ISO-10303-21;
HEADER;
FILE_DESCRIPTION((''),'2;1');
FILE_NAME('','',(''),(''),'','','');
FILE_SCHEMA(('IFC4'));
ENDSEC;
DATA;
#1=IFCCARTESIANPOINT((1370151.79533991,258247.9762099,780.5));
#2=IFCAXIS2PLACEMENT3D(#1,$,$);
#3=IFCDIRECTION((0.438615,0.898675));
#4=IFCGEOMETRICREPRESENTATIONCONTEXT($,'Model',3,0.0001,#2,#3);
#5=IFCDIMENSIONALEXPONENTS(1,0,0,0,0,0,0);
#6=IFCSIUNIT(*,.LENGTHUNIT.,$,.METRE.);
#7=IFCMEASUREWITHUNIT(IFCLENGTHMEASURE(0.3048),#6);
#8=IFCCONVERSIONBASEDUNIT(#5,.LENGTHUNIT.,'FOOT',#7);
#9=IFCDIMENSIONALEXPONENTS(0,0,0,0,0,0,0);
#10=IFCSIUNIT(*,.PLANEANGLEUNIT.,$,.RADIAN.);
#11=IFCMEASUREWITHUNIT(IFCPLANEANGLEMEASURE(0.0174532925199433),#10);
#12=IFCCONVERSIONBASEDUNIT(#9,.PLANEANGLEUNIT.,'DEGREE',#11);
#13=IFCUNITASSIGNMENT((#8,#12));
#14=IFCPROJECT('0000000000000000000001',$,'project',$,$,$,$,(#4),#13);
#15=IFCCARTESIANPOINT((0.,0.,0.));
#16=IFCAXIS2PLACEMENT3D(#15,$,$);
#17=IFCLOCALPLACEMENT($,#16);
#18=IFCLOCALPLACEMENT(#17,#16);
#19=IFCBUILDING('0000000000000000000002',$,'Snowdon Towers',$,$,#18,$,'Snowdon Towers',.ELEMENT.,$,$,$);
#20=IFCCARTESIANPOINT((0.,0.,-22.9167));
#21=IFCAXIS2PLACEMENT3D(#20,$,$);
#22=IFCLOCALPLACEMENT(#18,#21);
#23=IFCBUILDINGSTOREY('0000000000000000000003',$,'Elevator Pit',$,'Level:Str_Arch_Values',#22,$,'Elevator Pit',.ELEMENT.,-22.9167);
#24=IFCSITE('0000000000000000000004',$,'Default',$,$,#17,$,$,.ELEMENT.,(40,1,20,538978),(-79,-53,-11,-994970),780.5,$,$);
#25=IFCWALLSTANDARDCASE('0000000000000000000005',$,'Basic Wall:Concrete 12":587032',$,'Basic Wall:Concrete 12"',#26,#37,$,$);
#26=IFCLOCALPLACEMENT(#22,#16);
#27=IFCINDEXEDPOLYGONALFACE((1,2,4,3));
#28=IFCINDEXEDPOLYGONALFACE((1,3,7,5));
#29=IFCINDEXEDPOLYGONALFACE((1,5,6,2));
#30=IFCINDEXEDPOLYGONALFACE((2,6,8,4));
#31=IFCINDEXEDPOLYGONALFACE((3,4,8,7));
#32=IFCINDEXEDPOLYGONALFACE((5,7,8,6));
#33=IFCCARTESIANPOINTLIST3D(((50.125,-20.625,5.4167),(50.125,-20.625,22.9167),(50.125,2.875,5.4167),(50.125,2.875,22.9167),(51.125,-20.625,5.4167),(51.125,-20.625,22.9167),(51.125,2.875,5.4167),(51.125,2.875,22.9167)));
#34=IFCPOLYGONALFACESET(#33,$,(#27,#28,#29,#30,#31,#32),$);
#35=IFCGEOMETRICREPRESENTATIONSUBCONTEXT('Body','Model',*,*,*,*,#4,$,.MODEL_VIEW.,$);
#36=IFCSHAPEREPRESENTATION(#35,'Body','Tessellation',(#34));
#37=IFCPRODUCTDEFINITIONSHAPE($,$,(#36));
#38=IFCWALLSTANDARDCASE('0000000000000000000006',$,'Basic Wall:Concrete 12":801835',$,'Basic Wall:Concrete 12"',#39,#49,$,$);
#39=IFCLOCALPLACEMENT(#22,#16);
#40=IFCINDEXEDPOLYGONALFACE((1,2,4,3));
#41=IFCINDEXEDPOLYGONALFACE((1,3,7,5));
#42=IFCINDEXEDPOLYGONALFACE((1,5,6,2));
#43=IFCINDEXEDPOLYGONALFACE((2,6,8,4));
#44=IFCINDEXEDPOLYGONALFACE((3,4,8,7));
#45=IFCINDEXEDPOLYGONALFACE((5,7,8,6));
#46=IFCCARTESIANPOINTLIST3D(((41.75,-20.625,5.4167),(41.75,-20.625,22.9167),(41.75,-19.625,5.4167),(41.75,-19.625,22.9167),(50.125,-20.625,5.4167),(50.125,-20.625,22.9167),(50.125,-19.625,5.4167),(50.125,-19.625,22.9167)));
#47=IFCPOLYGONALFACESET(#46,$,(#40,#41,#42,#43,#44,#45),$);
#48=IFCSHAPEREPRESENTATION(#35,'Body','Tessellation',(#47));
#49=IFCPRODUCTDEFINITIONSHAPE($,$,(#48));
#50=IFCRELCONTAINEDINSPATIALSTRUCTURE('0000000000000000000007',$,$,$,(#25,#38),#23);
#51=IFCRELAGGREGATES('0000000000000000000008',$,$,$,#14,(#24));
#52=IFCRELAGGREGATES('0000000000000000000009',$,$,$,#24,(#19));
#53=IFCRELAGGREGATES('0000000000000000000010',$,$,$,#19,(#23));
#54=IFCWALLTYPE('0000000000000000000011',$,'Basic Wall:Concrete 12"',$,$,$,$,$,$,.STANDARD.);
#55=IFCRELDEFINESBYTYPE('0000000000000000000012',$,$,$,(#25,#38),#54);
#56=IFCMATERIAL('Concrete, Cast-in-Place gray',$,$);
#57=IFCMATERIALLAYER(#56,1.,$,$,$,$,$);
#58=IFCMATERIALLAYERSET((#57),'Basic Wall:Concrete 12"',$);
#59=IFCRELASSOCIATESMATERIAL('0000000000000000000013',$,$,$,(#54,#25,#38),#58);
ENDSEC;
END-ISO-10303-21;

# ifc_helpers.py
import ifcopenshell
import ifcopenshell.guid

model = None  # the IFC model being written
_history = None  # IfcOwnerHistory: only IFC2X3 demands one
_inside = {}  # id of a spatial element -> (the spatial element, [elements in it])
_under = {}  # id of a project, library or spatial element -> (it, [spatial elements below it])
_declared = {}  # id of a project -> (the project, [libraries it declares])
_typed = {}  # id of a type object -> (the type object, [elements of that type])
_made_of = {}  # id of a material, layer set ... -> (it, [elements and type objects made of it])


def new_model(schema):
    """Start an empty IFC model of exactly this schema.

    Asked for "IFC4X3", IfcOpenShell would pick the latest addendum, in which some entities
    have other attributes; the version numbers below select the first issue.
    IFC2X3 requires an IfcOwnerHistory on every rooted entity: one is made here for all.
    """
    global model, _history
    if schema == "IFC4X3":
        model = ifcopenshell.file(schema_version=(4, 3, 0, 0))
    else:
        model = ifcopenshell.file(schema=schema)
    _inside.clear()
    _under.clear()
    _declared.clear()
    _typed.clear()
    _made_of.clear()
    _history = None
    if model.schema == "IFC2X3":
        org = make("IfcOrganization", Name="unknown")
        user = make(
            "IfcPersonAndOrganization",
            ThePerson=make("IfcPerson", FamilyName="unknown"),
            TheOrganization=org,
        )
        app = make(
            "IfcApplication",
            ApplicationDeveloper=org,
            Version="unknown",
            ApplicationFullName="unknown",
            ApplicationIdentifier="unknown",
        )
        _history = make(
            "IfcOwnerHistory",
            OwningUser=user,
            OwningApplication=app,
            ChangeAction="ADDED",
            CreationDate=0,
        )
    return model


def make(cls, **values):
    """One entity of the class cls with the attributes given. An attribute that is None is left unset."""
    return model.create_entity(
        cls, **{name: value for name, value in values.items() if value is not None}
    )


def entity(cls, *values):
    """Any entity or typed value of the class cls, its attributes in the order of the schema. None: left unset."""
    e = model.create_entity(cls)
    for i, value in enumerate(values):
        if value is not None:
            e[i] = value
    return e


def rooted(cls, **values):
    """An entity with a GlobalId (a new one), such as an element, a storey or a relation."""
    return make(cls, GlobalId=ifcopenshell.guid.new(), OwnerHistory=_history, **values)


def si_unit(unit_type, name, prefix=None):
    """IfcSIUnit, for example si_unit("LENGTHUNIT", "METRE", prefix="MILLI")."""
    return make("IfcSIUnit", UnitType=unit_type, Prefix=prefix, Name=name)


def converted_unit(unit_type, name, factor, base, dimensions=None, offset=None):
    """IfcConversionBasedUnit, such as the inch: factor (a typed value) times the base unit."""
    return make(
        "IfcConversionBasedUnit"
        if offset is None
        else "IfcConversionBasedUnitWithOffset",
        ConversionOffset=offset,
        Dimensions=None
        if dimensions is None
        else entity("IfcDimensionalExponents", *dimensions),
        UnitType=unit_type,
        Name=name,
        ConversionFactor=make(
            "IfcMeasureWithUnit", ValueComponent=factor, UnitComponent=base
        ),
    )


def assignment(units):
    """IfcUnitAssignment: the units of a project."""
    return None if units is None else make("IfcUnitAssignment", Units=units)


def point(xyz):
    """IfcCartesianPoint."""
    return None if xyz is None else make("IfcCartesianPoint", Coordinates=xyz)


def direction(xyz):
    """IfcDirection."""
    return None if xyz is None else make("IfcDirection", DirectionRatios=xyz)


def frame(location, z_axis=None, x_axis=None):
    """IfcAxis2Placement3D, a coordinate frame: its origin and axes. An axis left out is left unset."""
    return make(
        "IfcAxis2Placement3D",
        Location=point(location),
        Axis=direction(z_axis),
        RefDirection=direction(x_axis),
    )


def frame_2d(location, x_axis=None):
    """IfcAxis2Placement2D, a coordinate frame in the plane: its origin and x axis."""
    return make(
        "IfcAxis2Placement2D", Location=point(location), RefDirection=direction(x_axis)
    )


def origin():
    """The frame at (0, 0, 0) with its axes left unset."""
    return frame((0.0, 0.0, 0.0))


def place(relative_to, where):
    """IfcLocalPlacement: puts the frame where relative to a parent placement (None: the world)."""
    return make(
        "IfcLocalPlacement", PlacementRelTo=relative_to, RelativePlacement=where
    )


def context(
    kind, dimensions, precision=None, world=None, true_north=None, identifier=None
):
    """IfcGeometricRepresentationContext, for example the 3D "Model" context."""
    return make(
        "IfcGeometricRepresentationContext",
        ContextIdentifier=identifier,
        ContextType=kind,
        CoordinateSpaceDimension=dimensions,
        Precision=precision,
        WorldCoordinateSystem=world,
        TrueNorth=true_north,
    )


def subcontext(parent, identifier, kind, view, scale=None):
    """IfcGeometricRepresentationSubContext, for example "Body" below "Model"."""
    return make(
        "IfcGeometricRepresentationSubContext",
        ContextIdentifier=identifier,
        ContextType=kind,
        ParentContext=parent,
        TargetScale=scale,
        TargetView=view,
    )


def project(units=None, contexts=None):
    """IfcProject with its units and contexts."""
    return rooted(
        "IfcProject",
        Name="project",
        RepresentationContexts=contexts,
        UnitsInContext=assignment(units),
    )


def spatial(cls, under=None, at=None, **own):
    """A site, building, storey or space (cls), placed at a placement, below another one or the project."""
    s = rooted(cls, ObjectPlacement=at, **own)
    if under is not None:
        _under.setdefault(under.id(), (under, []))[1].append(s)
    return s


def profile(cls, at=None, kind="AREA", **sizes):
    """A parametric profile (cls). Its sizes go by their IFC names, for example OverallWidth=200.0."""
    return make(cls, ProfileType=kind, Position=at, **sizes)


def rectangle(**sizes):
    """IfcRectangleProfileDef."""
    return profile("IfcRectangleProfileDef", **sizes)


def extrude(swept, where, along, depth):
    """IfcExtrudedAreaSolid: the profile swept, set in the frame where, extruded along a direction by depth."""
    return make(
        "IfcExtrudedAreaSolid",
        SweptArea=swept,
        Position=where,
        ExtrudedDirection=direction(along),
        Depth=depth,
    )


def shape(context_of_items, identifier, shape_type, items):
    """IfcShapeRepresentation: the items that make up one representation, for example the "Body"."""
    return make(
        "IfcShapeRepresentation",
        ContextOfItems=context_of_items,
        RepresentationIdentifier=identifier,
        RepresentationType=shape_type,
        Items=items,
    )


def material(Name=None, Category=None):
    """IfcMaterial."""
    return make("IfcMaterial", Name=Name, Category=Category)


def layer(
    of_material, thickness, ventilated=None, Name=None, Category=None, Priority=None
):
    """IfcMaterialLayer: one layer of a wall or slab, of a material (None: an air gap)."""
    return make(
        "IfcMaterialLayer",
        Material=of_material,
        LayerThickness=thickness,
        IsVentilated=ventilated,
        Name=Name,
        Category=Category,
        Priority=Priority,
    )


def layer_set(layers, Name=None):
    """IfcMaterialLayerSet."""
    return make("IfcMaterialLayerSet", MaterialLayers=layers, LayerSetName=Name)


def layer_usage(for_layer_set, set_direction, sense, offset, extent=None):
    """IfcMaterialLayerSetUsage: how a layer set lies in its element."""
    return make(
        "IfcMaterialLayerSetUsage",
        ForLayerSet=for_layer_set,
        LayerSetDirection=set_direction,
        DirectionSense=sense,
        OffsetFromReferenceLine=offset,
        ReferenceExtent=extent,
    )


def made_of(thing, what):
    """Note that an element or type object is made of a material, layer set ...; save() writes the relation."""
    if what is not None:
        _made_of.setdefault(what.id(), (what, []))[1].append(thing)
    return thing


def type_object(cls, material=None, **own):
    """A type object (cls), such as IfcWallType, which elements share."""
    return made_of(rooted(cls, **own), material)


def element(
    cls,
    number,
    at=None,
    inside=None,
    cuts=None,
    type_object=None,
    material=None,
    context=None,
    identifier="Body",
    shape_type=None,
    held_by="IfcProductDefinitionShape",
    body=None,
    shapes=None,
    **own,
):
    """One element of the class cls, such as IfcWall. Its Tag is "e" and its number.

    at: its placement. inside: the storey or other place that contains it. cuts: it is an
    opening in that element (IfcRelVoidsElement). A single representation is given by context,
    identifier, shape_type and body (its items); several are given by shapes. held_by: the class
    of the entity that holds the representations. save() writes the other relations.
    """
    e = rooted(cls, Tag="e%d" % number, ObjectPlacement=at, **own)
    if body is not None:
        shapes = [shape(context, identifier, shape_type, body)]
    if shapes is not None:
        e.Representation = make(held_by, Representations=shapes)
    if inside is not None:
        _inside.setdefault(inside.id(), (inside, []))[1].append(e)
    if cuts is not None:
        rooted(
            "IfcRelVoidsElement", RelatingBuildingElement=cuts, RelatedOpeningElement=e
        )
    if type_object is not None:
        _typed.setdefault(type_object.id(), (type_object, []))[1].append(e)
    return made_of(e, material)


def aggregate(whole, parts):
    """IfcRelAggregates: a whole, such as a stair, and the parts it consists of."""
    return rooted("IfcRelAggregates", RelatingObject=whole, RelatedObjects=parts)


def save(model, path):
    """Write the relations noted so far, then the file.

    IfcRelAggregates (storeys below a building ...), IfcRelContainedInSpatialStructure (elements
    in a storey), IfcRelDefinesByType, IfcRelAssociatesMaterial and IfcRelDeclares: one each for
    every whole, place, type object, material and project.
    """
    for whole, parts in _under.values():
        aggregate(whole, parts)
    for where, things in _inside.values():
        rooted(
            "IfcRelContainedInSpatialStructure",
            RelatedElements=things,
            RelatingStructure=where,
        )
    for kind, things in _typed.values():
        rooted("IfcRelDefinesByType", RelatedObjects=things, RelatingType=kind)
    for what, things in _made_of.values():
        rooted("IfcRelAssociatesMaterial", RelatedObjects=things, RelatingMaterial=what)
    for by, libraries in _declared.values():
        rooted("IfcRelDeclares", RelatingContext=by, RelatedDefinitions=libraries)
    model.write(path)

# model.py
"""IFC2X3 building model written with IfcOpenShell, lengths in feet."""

from ifc_helpers import new_model, entity, si_unit, converted_unit, direction, frame, frame_2d, origin, place, context, subcontext, project, spatial, rectangle, extrude, material, layer, layer_set, layer_usage, type_object, element, save


model = new_model("IFC2X3")

# Units and contexts
model_context = context("Model", 3, precision=0.0001, world=frame((1370151.79533991, 258247.9762099, 780.5)), true_north=direction((0.438615, 0.898675)))
body_context = subcontext(model_context, "Body", "Model", "MODEL_VIEW")
ifc_project = project(units=[converted_unit("LENGTHUNIT", "FOOT", entity("IfcLengthMeasure", 0.3048), si_unit("LENGTHUNIT", "METRE"), dimensions=[1, 0, 0, 0, 0, 0, 0]), converted_unit("PLANEANGLEUNIT", "DEGREE", entity("IfcPlaneAngleMeasure", 0.0174532925199433), si_unit("PLANEANGLEUNIT", "RADIAN"), dimensions=[0, 0, 0, 0, 0, 0, 0])], contexts=[model_context])

# Site, building, storey
site_placement = place(None, origin())
site = spatial("IfcSite", under=ifc_project, at=site_placement, Name="Default", CompositionType="ELEMENT", RefLatitude=(40, 1, 20, 538978), RefLongitude=(-79, -53, -11, -994970), RefElevation=780.5)
building_placement = place(site_placement, origin())
building = spatial("IfcBuilding", under=site, at=building_placement, Name="Snowdon Towers", LongName="Snowdon Towers", CompositionType="ELEMENT")
storey_placement = place(building_placement, frame((0.0, 0.0, -22.9167)))
storey = spatial("IfcBuildingStorey", under=building, at=storey_placement, Name="Elevator Pit", ObjectType="Level:Str_Arch_Values", LongName="Elevator Pit", CompositionType="ELEMENT", Elevation=-22.9167)

# Shared definitions
ifc_material_1 = material(Name="Concrete, Cast-in-Place gray")

# Walls
ifc_layer = layer(ifc_material_1, 1.0)
ifc_layer_set = layer_set([ifc_layer], Name="Basic Wall:Concrete 12\"")
ifc_layer_usage_1 = layer_usage(ifc_layer_set, "AXIS2", "NEGATIVE", 0.5)
wall_type = type_object("IfcWallType", Name="Basic Wall:Concrete 12\"", PredefinedType="STANDARD", material=ifc_layer_set)
wall_1_placement = place(storey_placement, frame((50.625, -20.625, 5.4167), z_axis=(0.0, 0.0, 1.0), x_axis=(0.0, 1.0, 0.0)))
element("IfcWallStandardCase", 1, at=wall_1_placement, inside=storey, type_object=wall_type, material=ifc_layer_usage_1, Name="Basic Wall:Concrete 12\":587032", ObjectType="Basic Wall:Concrete 12\"", context=body_context, shape_type="SweptSolid", body=[
    extrude(rectangle(XDim=23.5, YDim=1.0, at=frame_2d((11.75, 0.0), x_axis=(-1.0, 0.0))), origin(), (0.0, 0.0, 1.0), 17.5),
])
ifc_layer_usage_2 = layer_usage(ifc_layer_set, "AXIS2", "POSITIVE", -0.5)
wall_2_placement = place(storey_placement, frame((50.125, -20.125, 5.4167), z_axis=(0.0, 0.0, 1.0), x_axis=(-1.0, 0.0, 0.0)))
element("IfcWallStandardCase", 2, at=wall_2_placement, inside=storey, type_object=wall_type, material=ifc_layer_usage_2, Name="Basic Wall:Concrete 12\":801835", ObjectType="Basic Wall:Concrete 12\"", context=body_context, shape_type="SweptSolid", body=[
    extrude(rectangle(XDim=8.375, YDim=1.0, at=frame_2d((4.1875, 0.0), x_axis=(-1.0, 0.0))), origin(), (0.0, 0.0, 1.0), 17.5),
])

save(model, "model.ifc")
